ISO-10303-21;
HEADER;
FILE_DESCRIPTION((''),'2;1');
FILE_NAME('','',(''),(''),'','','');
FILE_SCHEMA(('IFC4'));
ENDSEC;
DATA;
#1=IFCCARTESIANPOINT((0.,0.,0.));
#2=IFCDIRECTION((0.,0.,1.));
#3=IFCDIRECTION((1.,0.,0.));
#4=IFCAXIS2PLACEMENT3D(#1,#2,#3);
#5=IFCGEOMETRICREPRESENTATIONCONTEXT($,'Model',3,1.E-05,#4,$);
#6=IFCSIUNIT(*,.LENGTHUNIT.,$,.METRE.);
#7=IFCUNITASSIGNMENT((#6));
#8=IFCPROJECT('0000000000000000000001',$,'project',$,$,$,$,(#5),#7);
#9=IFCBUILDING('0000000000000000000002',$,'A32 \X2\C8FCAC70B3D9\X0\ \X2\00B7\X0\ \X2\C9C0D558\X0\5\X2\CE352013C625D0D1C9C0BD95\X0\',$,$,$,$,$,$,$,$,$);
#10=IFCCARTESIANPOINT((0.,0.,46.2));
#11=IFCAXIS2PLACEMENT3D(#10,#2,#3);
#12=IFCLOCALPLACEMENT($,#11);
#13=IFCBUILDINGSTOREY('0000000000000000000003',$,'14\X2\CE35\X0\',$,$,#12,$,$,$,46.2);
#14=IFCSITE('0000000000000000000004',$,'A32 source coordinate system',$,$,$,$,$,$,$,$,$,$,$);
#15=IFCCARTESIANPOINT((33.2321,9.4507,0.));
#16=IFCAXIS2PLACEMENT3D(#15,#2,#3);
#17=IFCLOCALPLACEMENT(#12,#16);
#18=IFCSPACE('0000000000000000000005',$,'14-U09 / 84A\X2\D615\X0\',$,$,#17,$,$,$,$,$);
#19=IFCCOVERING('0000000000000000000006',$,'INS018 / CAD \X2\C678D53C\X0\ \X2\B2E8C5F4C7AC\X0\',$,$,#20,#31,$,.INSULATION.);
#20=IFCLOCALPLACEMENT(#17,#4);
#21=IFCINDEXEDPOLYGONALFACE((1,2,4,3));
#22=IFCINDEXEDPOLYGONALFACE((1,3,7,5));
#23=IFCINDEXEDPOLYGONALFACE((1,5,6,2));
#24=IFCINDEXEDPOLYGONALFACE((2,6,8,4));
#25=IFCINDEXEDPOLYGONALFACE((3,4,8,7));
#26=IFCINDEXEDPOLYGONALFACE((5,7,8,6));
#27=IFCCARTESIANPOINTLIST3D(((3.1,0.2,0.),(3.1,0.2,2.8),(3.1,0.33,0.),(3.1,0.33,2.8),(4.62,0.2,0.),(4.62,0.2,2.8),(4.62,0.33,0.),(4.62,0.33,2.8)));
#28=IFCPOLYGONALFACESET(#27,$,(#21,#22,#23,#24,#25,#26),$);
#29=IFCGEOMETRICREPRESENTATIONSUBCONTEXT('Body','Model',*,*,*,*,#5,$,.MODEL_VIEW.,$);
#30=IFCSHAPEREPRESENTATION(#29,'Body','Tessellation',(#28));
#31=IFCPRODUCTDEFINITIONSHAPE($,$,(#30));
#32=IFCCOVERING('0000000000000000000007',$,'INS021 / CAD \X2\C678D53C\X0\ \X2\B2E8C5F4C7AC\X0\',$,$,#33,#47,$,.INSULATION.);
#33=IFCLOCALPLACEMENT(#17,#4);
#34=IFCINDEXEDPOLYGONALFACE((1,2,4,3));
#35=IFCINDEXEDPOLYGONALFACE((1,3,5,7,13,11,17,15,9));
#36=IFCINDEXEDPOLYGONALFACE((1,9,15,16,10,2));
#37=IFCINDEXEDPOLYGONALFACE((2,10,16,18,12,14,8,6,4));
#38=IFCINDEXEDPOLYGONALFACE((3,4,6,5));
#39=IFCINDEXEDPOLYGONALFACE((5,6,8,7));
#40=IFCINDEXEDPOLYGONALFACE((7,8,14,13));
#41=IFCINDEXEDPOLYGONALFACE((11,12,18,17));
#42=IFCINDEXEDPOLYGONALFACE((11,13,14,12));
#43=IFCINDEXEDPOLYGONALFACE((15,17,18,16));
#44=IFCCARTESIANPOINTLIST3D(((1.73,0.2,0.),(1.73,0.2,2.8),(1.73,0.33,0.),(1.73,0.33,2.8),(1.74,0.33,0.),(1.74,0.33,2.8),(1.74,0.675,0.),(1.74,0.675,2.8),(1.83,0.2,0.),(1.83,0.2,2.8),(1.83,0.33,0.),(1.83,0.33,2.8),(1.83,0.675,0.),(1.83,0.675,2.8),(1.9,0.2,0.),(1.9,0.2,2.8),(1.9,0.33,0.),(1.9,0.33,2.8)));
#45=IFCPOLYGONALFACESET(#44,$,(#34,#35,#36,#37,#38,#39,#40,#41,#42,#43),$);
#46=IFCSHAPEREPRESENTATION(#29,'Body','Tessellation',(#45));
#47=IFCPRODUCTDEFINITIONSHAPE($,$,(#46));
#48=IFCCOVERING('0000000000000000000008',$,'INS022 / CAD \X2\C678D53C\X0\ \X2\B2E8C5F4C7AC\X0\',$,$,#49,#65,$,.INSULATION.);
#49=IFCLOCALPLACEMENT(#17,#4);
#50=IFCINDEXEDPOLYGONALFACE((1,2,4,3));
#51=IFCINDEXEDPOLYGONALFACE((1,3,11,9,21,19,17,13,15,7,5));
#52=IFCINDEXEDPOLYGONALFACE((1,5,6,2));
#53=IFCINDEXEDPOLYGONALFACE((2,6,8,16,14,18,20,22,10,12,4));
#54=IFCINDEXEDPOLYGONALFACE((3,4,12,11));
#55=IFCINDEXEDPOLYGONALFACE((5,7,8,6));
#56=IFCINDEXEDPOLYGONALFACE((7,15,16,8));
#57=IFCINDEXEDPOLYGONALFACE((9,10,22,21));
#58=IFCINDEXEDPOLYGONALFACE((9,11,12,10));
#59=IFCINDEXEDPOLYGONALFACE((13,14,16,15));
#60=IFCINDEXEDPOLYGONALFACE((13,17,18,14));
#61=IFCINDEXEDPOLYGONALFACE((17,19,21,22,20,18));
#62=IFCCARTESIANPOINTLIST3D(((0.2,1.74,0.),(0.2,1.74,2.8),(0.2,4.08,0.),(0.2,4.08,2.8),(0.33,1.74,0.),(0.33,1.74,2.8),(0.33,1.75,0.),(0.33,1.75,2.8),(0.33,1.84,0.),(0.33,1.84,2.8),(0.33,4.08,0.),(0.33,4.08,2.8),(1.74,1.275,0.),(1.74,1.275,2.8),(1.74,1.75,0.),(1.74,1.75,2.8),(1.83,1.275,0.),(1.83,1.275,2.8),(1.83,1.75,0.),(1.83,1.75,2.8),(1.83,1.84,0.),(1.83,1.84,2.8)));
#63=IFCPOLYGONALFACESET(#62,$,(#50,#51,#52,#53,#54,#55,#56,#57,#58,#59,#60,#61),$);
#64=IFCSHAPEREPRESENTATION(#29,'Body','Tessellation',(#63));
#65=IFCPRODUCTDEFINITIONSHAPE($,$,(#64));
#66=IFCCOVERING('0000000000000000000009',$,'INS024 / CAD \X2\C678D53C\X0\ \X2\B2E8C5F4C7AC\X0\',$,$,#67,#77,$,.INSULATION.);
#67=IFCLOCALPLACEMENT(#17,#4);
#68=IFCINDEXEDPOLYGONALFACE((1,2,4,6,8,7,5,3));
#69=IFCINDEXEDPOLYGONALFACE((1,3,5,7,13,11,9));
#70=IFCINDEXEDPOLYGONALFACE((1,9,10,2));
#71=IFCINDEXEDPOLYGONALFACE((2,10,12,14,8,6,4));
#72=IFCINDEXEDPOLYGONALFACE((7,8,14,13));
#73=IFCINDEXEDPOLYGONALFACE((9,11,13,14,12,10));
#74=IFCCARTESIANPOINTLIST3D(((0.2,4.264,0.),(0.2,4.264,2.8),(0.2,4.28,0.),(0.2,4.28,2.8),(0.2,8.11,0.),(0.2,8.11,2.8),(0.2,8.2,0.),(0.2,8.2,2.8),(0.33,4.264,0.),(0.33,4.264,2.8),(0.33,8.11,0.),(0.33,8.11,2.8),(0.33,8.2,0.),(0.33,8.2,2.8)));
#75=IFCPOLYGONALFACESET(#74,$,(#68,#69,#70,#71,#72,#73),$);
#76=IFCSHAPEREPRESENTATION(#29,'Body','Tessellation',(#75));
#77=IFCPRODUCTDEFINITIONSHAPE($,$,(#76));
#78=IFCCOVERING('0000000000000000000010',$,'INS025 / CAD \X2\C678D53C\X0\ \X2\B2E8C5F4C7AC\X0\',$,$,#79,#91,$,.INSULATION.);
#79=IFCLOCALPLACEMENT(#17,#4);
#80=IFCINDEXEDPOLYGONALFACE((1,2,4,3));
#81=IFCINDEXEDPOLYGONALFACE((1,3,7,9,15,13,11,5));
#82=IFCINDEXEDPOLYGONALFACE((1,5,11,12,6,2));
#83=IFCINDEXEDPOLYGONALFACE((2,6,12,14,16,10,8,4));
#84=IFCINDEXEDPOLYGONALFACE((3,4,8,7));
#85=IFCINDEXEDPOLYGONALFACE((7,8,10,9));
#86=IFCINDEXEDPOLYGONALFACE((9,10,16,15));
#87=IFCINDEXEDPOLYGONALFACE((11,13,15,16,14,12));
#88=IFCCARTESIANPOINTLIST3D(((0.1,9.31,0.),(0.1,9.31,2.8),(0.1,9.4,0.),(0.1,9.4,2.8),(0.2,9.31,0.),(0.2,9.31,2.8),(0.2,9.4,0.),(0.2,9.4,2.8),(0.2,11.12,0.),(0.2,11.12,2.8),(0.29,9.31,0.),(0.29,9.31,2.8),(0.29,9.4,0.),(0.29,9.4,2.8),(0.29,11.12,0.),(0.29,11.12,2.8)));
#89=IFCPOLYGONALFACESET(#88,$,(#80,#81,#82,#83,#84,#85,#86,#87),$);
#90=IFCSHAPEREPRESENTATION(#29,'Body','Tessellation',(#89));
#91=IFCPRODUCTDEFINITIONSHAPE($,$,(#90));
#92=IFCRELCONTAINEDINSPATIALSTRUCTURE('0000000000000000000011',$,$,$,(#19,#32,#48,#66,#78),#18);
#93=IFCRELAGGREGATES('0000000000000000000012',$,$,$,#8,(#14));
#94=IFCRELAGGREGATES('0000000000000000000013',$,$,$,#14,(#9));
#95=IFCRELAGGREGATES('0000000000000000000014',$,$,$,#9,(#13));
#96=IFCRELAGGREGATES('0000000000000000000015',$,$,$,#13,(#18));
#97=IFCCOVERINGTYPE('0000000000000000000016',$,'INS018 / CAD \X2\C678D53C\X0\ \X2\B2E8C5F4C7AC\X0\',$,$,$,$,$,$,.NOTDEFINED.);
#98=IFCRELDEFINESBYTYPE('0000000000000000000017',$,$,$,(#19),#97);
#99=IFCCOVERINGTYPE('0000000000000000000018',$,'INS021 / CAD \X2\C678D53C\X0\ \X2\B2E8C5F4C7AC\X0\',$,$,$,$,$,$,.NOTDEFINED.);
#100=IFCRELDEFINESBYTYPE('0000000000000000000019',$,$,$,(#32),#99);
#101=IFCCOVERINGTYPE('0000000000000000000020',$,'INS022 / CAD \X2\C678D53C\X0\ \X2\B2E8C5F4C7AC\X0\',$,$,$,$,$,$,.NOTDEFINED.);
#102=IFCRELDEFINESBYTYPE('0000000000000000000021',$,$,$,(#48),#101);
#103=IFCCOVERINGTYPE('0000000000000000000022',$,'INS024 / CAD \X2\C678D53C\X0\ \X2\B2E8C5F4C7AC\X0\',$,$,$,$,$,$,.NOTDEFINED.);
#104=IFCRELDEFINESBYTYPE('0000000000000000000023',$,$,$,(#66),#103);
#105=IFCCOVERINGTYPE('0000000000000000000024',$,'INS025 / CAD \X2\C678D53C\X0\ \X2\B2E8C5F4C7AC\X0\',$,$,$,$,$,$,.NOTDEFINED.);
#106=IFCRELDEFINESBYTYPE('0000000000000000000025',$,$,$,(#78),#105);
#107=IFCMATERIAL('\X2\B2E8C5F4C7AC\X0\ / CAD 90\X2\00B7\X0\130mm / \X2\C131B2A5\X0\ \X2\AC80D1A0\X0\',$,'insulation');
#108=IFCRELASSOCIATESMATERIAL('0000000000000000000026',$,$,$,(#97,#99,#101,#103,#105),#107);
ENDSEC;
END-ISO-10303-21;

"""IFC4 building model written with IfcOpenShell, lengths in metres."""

from ifc_helpers import new_model, si_unit, frame, origin, origin_with_axes, place, context, subcontext, project, spatial, polyline, outline, extrude, source, transform, mapped, material, type_object, type_shapes, element, save


model = new_model("IFC4")

# Units and contexts
model_context = context("Model", 3, precision=1e-05, world=origin_with_axes())
body_context = subcontext(model_context, "Body", "Model", "MODEL_VIEW")
ifc_project = project(units=[si_unit("LENGTHUNIT", "METRE")], contexts=[model_context])

# Site, building, storey, space
storey_placement = place(None, frame((0.0, 0.0, 46.2), z_axis=(0.0, 0.0, 1.0), x_axis=(1.0, 0.0, 0.0)))
space_placement = place(storey_placement, frame((33.2321, 9.4507, 0.0), z_axis=(0.0, 0.0, 1.0), x_axis=(1.0, 0.0, 0.0)))
site = spatial("IfcSite", under=ifc_project, Name="A32 source coordinate system")
building = spatial("IfcBuilding", under=site, Name="A32 주거동 · 지하5층–옥탑지붕")
storey = spatial("IfcBuildingStorey", under=building, at=storey_placement, Name="14층", Elevation=46.2)
space = spatial("IfcSpace", under=storey, at=space_placement, Name="14-U09 / 84A형")

# Coverings
ifc_material = material(Name="단열재 / CAD 90·130mm / 성능 검토", Category="insulation")
covering_type_1 = type_object("IfcCoveringType", Name="INS018 / CAD 외피 단열재", PredefinedType="NOTDEFINED", material=ifc_material)
shared_shape_1 = source(origin(), body_context, "Body", "SweptSolid", [
    extrude(outline(polyline([(3.1, 0.33), (4.62, 0.33), (4.62, 0.2), (3.1, 0.2), (3.1, 0.33)])), origin(), (0.0, 0.0, 1.0), 2.8),
])
type_shapes(covering_type_1, [shared_shape_1])
covering_1_placement = place(space_placement, origin_with_axes())
element("IfcCovering", 1, at=covering_1_placement, inside=space, type_object=covering_type_1, Name="INS018 / CAD 외피 단열재", PredefinedType="INSULATION", context=body_context, shape_type="MappedRepresentation", body=[
    mapped(shared_shape_1, transform((0.0, 0.0, 0.0), scale=1.0)),
])
covering_type_2 = type_object("IfcCoveringType", Name="INS021 / CAD 외피 단열재", PredefinedType="NOTDEFINED", material=ifc_material)
shared_shape_2 = source(origin(), body_context, "Body", "SweptSolid", [
    extrude(outline(polyline([(1.83, 0.33), (1.9, 0.33), (1.9, 0.2), (1.83, 0.2), (1.73, 0.2), (1.73, 0.33), (1.74, 0.33), (1.74, 0.675), (1.83, 0.675), (1.83, 0.33)])), origin(), (0.0, 0.0, 1.0), 2.8),
])
type_shapes(covering_type_2, [shared_shape_2])
covering_2_placement = place(space_placement, origin_with_axes())
element("IfcCovering", 2, at=covering_2_placement, inside=space, type_object=covering_type_2, Name="INS021 / CAD 외피 단열재", PredefinedType="INSULATION", context=body_context, shape_type="MappedRepresentation", body=[
    mapped(shared_shape_2, transform((0.0, 0.0, 0.0), scale=1.0)),
])
covering_type_3 = type_object("IfcCoveringType", Name="INS022 / CAD 외피 단열재", PredefinedType="NOTDEFINED", material=ifc_material)
shared_shape_3 = source(origin(), body_context, "Body", "SweptSolid", [
    extrude(outline(polyline([(1.83, 1.84), (1.83, 1.75), (1.83, 1.275), (1.74, 1.275), (1.74, 1.75), (0.33, 1.75), (0.33, 1.74), (0.2, 1.74), (0.2, 4.08), (0.33, 4.08), (0.33, 1.84), (1.83, 1.84)])), origin(), (0.0, 0.0, 1.0), 2.8),
])
type_shapes(covering_type_3, [shared_shape_3])
covering_3_placement = place(space_placement, origin_with_axes())
element("IfcCovering", 3, at=covering_3_placement, inside=space, type_object=covering_type_3, Name="INS022 / CAD 외피 단열재", PredefinedType="INSULATION", context=body_context, shape_type="MappedRepresentation", body=[
    mapped(shared_shape_3, transform((0.0, 0.0, 0.0), scale=1.0)),
])
covering_type_4 = type_object("IfcCoveringType", Name="INS024 / CAD 외피 단열재", PredefinedType="NOTDEFINED", material=ifc_material)
shared_shape_4 = source(origin(), body_context, "Body", "SweptSolid", [
    extrude(outline(polyline([(0.2, 8.11), (0.2, 8.2), (0.33, 8.2), (0.33, 8.11), (0.33, 4.264), (0.2, 4.264), (0.2, 4.28), (0.2, 8.11)])), origin(), (0.0, 0.0, 1.0), 2.8),
])
type_shapes(covering_type_4, [shared_shape_4])
covering_4_placement = place(space_placement, origin_with_axes())
element("IfcCovering", 4, at=covering_4_placement, inside=space, type_object=covering_type_4, Name="INS024 / CAD 외피 단열재", PredefinedType="INSULATION", context=body_context, shape_type="MappedRepresentation", body=[
    mapped(shared_shape_4, transform((0.0, 0.0, 0.0), scale=1.0)),
])
covering_type_5 = type_object("IfcCoveringType", Name="INS025 / CAD 외피 단열재", PredefinedType="NOTDEFINED", material=ifc_material)
shared_shape_5 = source(origin(), body_context, "Body", "SweptSolid", [
    extrude(outline(polyline([(0.2, 9.4), (0.2, 11.12), (0.29, 11.12), (0.29, 9.4), (0.29, 9.31), (0.2, 9.31), (0.1, 9.31), (0.1, 9.4), (0.2, 9.4)])), origin(), (0.0, 0.0, 1.0), 2.8),
])
type_shapes(covering_type_5, [shared_shape_5])
covering_5_placement = place(space_placement, origin_with_axes())
element("IfcCovering", 5, at=covering_5_placement, inside=space, type_object=covering_type_5, Name="INS025 / CAD 외피 단열재", PredefinedType="INSULATION", context=body_context, shape_type="MappedRepresentation", body=[
    mapped(shared_shape_5, transform((0.0, 0.0, 0.0), scale=1.0)),
])

save(model, "model.ifc")
